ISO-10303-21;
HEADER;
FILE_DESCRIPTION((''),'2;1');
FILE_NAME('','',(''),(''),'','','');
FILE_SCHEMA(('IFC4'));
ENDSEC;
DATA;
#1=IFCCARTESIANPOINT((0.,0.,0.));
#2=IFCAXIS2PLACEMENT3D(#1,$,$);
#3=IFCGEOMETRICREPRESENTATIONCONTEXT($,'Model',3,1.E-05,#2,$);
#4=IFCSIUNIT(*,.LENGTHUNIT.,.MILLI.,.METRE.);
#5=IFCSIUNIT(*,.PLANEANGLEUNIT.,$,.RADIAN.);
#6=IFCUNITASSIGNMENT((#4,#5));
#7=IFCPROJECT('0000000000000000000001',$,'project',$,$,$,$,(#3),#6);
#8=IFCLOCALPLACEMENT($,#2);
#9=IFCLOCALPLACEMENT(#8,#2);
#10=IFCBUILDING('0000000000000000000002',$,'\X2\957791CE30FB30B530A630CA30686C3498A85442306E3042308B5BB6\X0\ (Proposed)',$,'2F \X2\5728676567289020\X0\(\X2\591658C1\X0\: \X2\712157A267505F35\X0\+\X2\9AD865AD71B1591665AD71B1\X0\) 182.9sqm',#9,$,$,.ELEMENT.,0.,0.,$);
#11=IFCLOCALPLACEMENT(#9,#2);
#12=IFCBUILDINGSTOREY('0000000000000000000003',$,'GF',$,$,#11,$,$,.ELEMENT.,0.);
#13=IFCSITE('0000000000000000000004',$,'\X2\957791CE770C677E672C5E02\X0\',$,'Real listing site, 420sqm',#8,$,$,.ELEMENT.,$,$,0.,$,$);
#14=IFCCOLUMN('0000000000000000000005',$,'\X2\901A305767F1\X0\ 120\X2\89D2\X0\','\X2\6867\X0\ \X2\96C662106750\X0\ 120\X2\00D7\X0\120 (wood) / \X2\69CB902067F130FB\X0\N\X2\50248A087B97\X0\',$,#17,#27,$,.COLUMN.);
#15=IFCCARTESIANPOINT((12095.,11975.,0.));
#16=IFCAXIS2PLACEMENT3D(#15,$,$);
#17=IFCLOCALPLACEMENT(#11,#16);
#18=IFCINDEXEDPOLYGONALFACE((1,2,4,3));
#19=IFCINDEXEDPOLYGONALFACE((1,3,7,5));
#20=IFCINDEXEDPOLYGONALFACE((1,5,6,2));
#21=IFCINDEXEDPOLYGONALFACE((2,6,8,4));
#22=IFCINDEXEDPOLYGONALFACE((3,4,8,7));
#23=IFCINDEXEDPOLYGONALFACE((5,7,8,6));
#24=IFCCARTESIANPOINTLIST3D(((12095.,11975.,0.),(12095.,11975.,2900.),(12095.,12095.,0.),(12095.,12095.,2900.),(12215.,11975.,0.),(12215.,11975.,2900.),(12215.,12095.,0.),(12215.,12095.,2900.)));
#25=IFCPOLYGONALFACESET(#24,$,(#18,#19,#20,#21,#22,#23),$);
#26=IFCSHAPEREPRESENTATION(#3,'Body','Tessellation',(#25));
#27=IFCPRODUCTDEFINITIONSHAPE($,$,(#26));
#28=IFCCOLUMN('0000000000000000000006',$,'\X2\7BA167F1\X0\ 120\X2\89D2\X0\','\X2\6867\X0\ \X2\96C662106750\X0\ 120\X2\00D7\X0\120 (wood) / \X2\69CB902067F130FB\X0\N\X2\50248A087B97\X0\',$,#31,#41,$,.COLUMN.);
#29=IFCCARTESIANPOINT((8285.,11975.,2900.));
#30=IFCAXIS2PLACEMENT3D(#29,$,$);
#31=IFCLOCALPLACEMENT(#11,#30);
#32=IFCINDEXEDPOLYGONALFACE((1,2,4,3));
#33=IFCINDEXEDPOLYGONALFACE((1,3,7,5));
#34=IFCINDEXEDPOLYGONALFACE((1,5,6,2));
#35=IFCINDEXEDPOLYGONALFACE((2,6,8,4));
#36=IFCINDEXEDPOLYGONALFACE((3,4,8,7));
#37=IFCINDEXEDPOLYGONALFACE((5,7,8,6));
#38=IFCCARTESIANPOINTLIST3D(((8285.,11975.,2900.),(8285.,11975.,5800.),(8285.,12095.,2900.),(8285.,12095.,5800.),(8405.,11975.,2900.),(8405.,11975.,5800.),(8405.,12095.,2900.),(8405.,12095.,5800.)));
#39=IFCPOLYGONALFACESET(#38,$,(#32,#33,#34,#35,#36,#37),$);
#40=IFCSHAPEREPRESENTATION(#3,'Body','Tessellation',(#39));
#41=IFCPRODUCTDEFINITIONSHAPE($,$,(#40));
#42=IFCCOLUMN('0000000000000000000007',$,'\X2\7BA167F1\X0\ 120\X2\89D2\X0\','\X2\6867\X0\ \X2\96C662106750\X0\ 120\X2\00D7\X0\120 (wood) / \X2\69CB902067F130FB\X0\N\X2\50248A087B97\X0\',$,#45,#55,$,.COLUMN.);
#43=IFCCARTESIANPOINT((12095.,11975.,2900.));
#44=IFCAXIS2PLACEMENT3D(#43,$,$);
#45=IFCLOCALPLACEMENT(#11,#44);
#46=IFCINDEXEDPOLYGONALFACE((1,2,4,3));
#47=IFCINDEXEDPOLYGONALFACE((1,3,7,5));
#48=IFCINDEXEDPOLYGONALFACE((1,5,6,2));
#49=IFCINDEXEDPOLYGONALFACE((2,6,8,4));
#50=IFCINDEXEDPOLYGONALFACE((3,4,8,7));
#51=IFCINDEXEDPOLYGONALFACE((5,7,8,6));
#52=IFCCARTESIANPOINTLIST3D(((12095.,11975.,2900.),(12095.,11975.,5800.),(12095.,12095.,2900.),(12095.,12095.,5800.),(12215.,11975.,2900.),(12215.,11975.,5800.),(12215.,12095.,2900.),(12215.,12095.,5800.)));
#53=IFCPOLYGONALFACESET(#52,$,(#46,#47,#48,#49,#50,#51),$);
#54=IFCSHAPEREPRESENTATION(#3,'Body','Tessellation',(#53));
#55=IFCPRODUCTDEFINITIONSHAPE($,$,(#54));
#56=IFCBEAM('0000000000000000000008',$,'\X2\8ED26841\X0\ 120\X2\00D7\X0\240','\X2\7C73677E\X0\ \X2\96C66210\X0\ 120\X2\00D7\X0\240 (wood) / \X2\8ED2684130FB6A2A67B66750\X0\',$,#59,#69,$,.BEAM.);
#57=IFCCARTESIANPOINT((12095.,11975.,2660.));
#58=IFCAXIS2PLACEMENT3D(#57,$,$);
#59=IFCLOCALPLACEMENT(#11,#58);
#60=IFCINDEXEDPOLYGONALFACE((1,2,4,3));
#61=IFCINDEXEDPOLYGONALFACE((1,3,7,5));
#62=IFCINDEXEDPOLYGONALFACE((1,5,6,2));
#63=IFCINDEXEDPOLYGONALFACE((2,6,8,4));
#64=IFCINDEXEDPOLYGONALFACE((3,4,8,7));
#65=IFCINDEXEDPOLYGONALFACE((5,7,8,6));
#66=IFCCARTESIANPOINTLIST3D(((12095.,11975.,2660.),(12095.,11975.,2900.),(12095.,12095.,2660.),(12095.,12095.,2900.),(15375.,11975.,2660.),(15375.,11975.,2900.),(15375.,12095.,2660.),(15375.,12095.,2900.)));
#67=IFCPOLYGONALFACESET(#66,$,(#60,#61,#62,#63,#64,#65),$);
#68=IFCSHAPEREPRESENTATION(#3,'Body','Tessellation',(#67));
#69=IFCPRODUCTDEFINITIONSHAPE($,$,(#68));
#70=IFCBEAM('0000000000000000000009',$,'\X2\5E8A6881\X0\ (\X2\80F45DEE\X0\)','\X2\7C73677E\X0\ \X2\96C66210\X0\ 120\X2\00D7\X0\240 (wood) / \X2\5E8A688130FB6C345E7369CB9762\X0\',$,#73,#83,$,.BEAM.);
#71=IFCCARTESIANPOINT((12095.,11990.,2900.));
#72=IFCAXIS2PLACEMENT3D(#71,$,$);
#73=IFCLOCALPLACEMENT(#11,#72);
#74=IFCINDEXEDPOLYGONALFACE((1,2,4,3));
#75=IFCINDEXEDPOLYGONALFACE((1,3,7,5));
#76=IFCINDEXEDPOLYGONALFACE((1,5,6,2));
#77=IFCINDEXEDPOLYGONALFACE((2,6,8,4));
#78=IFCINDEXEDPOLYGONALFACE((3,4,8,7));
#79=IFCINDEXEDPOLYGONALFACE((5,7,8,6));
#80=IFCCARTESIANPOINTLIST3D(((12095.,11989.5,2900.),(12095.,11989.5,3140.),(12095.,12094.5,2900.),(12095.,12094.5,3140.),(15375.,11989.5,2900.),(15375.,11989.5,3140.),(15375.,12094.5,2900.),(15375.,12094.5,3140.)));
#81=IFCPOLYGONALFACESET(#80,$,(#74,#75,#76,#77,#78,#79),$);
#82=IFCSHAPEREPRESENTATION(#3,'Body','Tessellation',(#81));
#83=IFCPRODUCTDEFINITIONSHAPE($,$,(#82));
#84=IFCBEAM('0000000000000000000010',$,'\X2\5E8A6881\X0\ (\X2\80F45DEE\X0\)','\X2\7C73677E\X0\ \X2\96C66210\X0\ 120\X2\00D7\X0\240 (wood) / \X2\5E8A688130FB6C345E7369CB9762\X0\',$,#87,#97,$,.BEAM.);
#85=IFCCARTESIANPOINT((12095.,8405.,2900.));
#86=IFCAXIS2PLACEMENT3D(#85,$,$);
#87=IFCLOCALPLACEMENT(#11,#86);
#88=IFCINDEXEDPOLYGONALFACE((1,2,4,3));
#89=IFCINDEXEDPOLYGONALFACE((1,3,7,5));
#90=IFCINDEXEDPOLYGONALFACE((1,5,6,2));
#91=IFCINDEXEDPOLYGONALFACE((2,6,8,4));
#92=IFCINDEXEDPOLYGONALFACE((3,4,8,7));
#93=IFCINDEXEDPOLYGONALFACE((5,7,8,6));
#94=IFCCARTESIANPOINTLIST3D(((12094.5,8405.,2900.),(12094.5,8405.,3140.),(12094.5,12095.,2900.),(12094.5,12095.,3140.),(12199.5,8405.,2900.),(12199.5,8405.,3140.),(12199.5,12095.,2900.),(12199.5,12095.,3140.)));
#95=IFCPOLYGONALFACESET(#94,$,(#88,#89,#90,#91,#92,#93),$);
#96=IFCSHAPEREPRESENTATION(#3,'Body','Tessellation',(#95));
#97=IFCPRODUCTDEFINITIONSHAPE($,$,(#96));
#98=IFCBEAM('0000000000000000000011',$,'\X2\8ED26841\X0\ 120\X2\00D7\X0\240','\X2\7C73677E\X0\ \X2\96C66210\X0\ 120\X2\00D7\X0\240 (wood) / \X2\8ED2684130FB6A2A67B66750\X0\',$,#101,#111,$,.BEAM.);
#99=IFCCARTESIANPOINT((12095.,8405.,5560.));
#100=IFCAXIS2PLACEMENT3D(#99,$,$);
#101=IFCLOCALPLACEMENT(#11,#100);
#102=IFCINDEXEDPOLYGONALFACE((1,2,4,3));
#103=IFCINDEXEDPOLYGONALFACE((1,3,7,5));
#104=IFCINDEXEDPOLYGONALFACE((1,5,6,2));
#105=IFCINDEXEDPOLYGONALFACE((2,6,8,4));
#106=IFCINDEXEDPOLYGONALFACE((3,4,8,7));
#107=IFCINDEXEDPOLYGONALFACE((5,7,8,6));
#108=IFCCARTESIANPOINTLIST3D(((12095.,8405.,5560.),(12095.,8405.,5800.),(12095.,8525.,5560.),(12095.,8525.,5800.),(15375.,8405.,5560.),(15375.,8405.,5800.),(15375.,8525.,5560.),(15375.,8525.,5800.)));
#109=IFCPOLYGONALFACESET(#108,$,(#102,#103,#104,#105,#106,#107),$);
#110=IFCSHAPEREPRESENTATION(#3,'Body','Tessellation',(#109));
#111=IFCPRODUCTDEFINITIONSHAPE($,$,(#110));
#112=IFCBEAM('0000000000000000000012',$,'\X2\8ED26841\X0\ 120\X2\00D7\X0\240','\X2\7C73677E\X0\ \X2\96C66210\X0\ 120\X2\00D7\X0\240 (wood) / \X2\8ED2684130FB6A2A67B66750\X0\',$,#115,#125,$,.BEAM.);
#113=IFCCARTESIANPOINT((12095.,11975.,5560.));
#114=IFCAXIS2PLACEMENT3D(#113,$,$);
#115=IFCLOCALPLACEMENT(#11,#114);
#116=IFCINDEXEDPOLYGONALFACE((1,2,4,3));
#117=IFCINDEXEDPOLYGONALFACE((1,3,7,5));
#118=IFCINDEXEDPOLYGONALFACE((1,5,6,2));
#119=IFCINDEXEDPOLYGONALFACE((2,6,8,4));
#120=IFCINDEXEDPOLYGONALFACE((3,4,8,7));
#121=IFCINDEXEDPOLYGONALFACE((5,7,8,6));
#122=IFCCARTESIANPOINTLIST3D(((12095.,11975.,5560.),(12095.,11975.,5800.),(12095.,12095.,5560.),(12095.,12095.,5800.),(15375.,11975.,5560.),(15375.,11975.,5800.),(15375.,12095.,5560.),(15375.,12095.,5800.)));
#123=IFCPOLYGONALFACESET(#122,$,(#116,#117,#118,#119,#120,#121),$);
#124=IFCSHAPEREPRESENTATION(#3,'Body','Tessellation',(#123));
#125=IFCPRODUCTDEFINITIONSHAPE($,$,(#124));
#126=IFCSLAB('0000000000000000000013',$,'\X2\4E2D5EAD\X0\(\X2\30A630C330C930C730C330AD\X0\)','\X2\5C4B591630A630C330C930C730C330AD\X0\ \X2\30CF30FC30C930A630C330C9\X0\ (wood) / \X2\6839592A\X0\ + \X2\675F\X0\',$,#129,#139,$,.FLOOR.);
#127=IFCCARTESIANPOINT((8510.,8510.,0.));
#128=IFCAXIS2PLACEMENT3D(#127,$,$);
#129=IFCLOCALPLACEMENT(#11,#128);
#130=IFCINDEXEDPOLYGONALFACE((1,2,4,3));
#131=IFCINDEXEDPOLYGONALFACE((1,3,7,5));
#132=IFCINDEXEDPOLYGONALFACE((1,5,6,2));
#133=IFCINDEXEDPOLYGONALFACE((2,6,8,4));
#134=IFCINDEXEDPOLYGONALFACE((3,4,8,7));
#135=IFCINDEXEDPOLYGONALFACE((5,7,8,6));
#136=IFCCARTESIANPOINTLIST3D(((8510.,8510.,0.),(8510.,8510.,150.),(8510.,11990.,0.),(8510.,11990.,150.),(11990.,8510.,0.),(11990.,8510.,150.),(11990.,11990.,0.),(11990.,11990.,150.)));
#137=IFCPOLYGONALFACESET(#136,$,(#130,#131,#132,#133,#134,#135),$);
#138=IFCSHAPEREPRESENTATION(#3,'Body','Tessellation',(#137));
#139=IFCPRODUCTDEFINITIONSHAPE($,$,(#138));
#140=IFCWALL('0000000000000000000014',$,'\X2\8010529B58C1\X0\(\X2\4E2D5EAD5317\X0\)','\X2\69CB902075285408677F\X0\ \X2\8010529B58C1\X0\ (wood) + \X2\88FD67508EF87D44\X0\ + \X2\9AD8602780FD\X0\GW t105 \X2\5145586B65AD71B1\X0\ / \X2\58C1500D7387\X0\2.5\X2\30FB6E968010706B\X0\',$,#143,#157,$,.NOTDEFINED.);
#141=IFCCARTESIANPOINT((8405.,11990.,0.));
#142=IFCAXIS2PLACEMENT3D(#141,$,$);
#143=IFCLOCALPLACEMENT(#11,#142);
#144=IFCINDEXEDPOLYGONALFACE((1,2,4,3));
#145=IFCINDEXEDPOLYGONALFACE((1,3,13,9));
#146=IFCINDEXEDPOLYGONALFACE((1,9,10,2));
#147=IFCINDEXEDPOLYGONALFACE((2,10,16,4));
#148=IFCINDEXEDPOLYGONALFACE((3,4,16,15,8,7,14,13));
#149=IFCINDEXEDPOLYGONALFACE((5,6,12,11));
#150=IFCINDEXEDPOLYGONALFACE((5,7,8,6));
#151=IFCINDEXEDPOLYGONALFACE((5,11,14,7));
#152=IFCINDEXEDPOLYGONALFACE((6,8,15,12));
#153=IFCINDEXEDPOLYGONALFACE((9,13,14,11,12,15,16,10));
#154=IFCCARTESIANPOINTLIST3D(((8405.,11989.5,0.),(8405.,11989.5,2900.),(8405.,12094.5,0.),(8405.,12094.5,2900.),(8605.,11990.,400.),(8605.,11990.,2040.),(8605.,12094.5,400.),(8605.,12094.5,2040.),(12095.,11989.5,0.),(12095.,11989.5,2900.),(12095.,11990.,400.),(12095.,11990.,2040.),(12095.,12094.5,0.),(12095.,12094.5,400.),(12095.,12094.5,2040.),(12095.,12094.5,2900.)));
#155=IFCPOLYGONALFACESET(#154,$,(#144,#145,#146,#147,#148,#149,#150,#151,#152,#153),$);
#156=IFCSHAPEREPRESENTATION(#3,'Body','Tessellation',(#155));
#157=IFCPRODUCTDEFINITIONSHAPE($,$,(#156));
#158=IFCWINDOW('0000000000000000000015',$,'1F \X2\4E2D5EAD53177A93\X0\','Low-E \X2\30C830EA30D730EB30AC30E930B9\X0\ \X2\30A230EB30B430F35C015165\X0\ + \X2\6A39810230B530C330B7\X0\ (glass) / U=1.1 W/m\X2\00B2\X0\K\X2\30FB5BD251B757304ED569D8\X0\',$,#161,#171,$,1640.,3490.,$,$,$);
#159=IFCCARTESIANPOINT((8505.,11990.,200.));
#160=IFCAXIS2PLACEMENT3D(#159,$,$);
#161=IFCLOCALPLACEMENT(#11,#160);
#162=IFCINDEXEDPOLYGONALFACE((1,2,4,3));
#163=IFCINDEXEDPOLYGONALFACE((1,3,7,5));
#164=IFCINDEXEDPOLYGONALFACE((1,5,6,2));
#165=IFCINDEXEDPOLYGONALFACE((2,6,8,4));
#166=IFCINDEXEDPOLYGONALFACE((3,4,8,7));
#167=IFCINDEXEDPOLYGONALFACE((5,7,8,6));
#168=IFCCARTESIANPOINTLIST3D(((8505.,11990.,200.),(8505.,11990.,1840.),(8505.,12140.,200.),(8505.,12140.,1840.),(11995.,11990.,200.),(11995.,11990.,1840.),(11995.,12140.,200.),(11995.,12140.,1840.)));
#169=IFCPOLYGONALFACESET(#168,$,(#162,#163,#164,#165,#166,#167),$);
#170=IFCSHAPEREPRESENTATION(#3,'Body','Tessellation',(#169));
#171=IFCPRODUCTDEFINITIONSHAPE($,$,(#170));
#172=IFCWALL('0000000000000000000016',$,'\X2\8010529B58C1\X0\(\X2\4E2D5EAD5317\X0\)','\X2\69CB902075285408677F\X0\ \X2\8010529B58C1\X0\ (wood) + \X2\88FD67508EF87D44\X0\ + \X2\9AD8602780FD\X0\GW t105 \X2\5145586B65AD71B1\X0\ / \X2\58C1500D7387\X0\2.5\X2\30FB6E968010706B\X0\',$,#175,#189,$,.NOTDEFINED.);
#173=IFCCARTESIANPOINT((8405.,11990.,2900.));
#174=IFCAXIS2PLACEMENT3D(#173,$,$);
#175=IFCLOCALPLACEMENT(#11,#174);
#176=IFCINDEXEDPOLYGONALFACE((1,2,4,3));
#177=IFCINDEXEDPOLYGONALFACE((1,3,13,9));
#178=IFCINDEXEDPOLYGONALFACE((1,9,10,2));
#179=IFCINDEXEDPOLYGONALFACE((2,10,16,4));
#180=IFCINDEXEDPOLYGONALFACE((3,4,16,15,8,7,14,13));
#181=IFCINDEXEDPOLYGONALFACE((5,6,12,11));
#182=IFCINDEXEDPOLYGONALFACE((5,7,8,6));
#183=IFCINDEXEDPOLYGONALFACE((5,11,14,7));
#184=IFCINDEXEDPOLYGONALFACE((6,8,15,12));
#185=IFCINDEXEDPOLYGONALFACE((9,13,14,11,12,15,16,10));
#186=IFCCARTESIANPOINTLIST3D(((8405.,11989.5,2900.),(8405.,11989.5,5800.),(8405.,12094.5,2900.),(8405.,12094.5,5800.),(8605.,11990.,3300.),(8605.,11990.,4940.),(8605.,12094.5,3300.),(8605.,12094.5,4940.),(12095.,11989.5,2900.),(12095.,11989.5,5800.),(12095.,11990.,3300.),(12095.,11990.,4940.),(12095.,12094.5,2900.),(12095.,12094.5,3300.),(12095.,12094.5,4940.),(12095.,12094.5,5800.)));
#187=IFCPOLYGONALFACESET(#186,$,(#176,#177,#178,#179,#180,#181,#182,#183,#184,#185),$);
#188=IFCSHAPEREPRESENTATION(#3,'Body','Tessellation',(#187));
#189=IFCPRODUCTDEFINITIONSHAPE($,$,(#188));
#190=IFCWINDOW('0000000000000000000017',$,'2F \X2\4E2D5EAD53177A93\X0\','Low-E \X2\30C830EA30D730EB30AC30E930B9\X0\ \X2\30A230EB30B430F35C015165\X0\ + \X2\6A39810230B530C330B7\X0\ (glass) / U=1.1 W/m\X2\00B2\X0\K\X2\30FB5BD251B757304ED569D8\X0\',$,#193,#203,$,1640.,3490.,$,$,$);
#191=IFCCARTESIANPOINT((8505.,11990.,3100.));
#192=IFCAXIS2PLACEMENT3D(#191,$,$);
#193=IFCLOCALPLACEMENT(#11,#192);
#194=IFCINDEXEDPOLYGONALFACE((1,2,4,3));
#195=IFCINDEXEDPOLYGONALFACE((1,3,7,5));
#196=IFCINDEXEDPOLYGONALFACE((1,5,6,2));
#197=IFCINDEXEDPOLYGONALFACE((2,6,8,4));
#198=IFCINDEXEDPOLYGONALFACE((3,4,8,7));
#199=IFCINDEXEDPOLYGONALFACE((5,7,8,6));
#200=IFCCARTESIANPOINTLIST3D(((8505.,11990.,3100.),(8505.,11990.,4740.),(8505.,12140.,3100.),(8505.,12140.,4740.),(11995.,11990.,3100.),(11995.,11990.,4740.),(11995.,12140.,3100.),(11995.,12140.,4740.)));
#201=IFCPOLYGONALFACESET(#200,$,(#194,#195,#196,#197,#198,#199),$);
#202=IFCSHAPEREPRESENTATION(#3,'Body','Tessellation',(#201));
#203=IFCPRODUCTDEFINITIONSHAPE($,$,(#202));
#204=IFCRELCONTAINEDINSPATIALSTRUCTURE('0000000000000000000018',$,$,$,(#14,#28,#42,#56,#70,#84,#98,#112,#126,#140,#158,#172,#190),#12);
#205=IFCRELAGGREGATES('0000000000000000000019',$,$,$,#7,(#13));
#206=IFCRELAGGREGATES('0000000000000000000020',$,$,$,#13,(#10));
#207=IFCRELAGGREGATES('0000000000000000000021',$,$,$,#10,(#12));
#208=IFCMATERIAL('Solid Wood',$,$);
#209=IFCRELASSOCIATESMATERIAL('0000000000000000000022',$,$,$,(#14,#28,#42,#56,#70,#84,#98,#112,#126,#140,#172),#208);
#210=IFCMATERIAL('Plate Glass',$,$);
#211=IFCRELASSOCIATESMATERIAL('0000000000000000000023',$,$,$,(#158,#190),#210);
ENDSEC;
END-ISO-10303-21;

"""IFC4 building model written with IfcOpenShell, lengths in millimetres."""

from ifc_helpers import new_model, si_unit, frame, frame_2d, origin, place, context, project, spatial, rectangle, extrude, material, element, fill, save


model = new_model("IFC4")

# Units and contexts
model_context = context("Model", 3, precision=1e-05, world=origin())
ifc_project = project(units=[si_unit("LENGTHUNIT", "METRE", prefix="MILLI"), si_unit("PLANEANGLEUNIT", "RADIAN")], contexts=[model_context])

# Site, building, storey
site_placement = place(None, origin())
site = spatial("IfcSite", under=ifc_project, at=site_placement, Name="長野県松本市", ObjectType="Real listing site, 420sqm", CompositionType="ELEMENT", RefElevation=0.0)
building_placement = place(site_placement, origin())
building = spatial("IfcBuilding", under=site, at=building_placement, Name="長野・サウナと水風呂のある家 (Proposed)", ObjectType="2F 在来木造(外壁: 無垢材張+高断熱外断熱) 182.9sqm", CompositionType="ELEMENT", ElevationOfRefHeight=0.0, ElevationOfTerrain=0.0)
storey_placement = place(building_placement, origin())
storey = spatial("IfcBuildingStorey", under=building, at=storey_placement, Name="GF", CompositionType="ELEMENT", Elevation=0.0)

# Columns
ifc_material_1 = material(Name="Solid Wood")
column_1_placement = place(storey_placement, frame((12095.0, 11975.0, 0.0)))
element("IfcColumn", 1, at=column_1_placement, inside=storey, material=ifc_material_1, Name="通し柱 120角", Description="桧 集成材 120×120 (wood) / 構造柱・N値計算", PredefinedType="COLUMN", context=model_context, shape_type="SweptSolid", body=[
    extrude(rectangle(XDim=120.0, YDim=120.0, at=frame_2d((60.0, 60.0))), frame((12095.0, 11975.0, 0.0)), (0.0, 0.0, 1.0), 2900.0),
])
column_2_placement = place(storey_placement, frame((8285.0, 11975.0, 2900.0)))
element("IfcColumn", 2, at=column_2_placement, inside=storey, material=ifc_material_1, Name="管柱 120角", Description="桧 集成材 120×120 (wood) / 構造柱・N値計算", PredefinedType="COLUMN", context=model_context, shape_type="SweptSolid", body=[
    extrude(rectangle(XDim=120.0, YDim=120.0, at=frame_2d((60.0, 60.0))), frame((8285.0, 11975.0, 2900.0)), (0.0, 0.0, 1.0), 2900.0),
])
column_3_placement = place(storey_placement, frame((12095.0, 11975.0, 2900.0)))
element("IfcColumn", 3, at=column_3_placement, inside=storey, material=ifc_material_1, Name="管柱 120角", Description="桧 集成材 120×120 (wood) / 構造柱・N値計算", PredefinedType="COLUMN", context=model_context, shape_type="SweptSolid", body=[
    extrude(rectangle(XDim=120.0, YDim=120.0, at=frame_2d((60.0, 60.0))), frame((12095.0, 11975.0, 2900.0)), (0.0, 0.0, 1.0), 2900.0),
])

# Beams
beam_1_placement = place(storey_placement, frame((12095.0, 11975.0, 2660.0)))
element("IfcBeam", 4, at=beam_1_placement, inside=storey, material=ifc_material_1, Name="軒桁 120×240", Description="米松 集成 120×240 (wood) / 軒桁・横架材", PredefinedType="BEAM", context=model_context, shape_type="SweptSolid", body=[
    extrude(rectangle(XDim=3280.0, YDim=120.0, at=frame_2d((1640.0, 60.0))), frame((12095.0, 11975.0, 2660.0)), (0.0, 0.0, 1.0), 240.0),
])
beam_2_placement = place(storey_placement, frame((12095.0, 11990.0, 2900.0)))
element("IfcBeam", 5, at=beam_2_placement, inside=storey, material=ifc_material_1, Name="床梁 (胴差)", Description="米松 集成 120×240 (wood) / 床梁・水平構面", PredefinedType="BEAM", context=model_context, shape_type="SweptSolid", body=[
    extrude(rectangle(XDim=3280.0, YDim=105.0, at=frame_2d((1640.0, 52.0))), frame((12095.0, 11990.0, 2900.0)), (0.0, 0.0, 1.0), 240.0),
])
beam_3_placement = place(storey_placement, frame((12095.0, 8405.0, 2900.0)))
element("IfcBeam", 6, at=beam_3_placement, inside=storey, material=ifc_material_1, Name="床梁 (胴差)", Description="米松 集成 120×240 (wood) / 床梁・水平構面", PredefinedType="BEAM", context=model_context, shape_type="SweptSolid", body=[
    extrude(rectangle(XDim=105.0, YDim=3690.0, at=frame_2d((52.0, 1845.0))), frame((12095.0, 8405.0, 2900.0)), (0.0, 0.0, 1.0), 240.0),
])
beam_4_placement = place(storey_placement, frame((12095.0, 8405.0, 5560.0)))
element("IfcBeam", 7, at=beam_4_placement, inside=storey, material=ifc_material_1, Name="軒桁 120×240", Description="米松 集成 120×240 (wood) / 軒桁・横架材", PredefinedType="BEAM", context=model_context, shape_type="SweptSolid", body=[
    extrude(rectangle(XDim=3280.0, YDim=120.0, at=frame_2d((1640.0, 60.0))), frame((12095.0, 8405.0, 5560.0)), (0.0, 0.0, 1.0), 240.0),
])
beam_5_placement = place(storey_placement, frame((12095.0, 11975.0, 5560.0)))
element("IfcBeam", 8, at=beam_5_placement, inside=storey, material=ifc_material_1, Name="軒桁 120×240", Description="米松 集成 120×240 (wood) / 軒桁・横架材", PredefinedType="BEAM", context=model_context, shape_type="SweptSolid", body=[
    extrude(rectangle(XDim=3280.0, YDim=120.0, at=frame_2d((1640.0, 60.0))), frame((12095.0, 11975.0, 5560.0)), (0.0, 0.0, 1.0), 240.0),
])

# Slab
slab_placement = place(storey_placement, frame((8510.0, 8510.0, 0.0)))
element("IfcSlab", 9, at=slab_placement, inside=storey, material=ifc_material_1, Name="中庭(ウッドデッキ)", Description="屋外ウッドデッキ ハードウッド (wood) / 根太 + 束", PredefinedType="FLOOR", context=model_context, shape_type="SweptSolid", body=[
    extrude(rectangle(XDim=3480.0, YDim=3480.0, at=frame_2d((1740.0, 1740.0))), frame((8510.0, 8510.0, 0.0)), (0.0, 0.0, 1.0), 150.0),
])

# Wall, opening, window
wall_1_placement = place(storey_placement, frame((8405.0, 11990.0, 0.0)))
wall_1 = element("IfcWall", 10, at=wall_1_placement, inside=storey, material=ifc_material_1, Name="耐力壁(中庭北)", Description="構造用合板 耐力壁 (wood) + 製材軸組 + 高性能GW t105 充填断熱 / 壁倍率2.5・準耐火", PredefinedType="NOTDEFINED", context=model_context, shape_type="SweptSolid", body=[
    extrude(rectangle(XDim=3690.0, YDim=105.0, at=frame_2d((1845.0, 52.0))), frame((8405.0, 11990.0, 0.0)), (0.0, 0.0, 1.0), 2900.0),
])
opening_1_placement = place(storey_placement, frame((8505.0, 11990.0, 200.0)))
opening_1 = element("IfcOpeningElement", 11, at=opening_1_placement, cuts=wall_1, PredefinedType="NOTDEFINED", context=model_context, shape_type="SweptSolid", body=[
    extrude(rectangle(XDim=3490.0, YDim=150.0, at=frame_2d((1745.0, 75.0))), frame((8505.0, 11990.0, 200.0)), (0.0, 0.0, 1.0), 1640.0),
])
ifc_material_2 = material(Name="Plate Glass")
window_1_placement = place(storey_placement, frame((8505.0, 11990.0, 200.0)))
window_1 = element("IfcWindow", 12, at=window_1_placement, inside=storey, material=ifc_material_2, Name="1F 中庭北窓", Description="Low-E トリプルガラス アルゴン封入 + 樹脂サッシ (glass) / U=1.1 W/m²K・寒冷地仕様", OverallHeight=1640.0, OverallWidth=3490.0, context=model_context, shape_type="SweptSolid", body=[
    extrude(rectangle(XDim=3490.0, YDim=150.0, at=frame_2d((1745.0, 75.0))), frame((8505.0, 11990.0, 200.0)), (0.0, 0.0, 1.0), 1640.0),
])
fill(opening_1, window_1)

# Wall, opening, window
wall_2_placement = place(storey_placement, frame((8405.0, 11990.0, 2900.0)))
wall_2 = element("IfcWall", 13, at=wall_2_placement, inside=storey, material=ifc_material_1, Name="耐力壁(中庭北)", Description="構造用合板 耐力壁 (wood) + 製材軸組 + 高性能GW t105 充填断熱 / 壁倍率2.5・準耐火", PredefinedType="NOTDEFINED", context=model_context, shape_type="SweptSolid", body=[
    extrude(rectangle(XDim=3690.0, YDim=105.0, at=frame_2d((1845.0, 52.0))), frame((8405.0, 11990.0, 2900.0)), (0.0, 0.0, 1.0), 2900.0),
])
opening_2_placement = place(storey_placement, frame((8505.0, 11990.0, 3100.0)))
opening_2 = element("IfcOpeningElement", 14, at=opening_2_placement, cuts=wall_2, PredefinedType="NOTDEFINED", context=model_context, shape_type="SweptSolid", body=[
    extrude(rectangle(XDim=3490.0, YDim=150.0, at=frame_2d((1745.0, 75.0))), frame((8505.0, 11990.0, 3100.0)), (0.0, 0.0, 1.0), 1640.0),
])
window_2_placement = place(storey_placement, frame((8505.0, 11990.0, 3100.0)))
window_2 = element("IfcWindow", 15, at=window_2_placement, inside=storey, material=ifc_material_2, Name="2F 中庭北窓", Description="Low-E トリプルガラス アルゴン封入 + 樹脂サッシ (glass) / U=1.1 W/m²K・寒冷地仕様", OverallHeight=1640.0, OverallWidth=3490.0, context=model_context, shape_type="SweptSolid", body=[
    extrude(rectangle(XDim=3490.0, YDim=150.0, at=frame_2d((1745.0, 75.0))), frame((8505.0, 11990.0, 3100.0)), (0.0, 0.0, 1.0), 1640.0),
])
fill(opening_2, window_2)

save(model, "model.ifc")
